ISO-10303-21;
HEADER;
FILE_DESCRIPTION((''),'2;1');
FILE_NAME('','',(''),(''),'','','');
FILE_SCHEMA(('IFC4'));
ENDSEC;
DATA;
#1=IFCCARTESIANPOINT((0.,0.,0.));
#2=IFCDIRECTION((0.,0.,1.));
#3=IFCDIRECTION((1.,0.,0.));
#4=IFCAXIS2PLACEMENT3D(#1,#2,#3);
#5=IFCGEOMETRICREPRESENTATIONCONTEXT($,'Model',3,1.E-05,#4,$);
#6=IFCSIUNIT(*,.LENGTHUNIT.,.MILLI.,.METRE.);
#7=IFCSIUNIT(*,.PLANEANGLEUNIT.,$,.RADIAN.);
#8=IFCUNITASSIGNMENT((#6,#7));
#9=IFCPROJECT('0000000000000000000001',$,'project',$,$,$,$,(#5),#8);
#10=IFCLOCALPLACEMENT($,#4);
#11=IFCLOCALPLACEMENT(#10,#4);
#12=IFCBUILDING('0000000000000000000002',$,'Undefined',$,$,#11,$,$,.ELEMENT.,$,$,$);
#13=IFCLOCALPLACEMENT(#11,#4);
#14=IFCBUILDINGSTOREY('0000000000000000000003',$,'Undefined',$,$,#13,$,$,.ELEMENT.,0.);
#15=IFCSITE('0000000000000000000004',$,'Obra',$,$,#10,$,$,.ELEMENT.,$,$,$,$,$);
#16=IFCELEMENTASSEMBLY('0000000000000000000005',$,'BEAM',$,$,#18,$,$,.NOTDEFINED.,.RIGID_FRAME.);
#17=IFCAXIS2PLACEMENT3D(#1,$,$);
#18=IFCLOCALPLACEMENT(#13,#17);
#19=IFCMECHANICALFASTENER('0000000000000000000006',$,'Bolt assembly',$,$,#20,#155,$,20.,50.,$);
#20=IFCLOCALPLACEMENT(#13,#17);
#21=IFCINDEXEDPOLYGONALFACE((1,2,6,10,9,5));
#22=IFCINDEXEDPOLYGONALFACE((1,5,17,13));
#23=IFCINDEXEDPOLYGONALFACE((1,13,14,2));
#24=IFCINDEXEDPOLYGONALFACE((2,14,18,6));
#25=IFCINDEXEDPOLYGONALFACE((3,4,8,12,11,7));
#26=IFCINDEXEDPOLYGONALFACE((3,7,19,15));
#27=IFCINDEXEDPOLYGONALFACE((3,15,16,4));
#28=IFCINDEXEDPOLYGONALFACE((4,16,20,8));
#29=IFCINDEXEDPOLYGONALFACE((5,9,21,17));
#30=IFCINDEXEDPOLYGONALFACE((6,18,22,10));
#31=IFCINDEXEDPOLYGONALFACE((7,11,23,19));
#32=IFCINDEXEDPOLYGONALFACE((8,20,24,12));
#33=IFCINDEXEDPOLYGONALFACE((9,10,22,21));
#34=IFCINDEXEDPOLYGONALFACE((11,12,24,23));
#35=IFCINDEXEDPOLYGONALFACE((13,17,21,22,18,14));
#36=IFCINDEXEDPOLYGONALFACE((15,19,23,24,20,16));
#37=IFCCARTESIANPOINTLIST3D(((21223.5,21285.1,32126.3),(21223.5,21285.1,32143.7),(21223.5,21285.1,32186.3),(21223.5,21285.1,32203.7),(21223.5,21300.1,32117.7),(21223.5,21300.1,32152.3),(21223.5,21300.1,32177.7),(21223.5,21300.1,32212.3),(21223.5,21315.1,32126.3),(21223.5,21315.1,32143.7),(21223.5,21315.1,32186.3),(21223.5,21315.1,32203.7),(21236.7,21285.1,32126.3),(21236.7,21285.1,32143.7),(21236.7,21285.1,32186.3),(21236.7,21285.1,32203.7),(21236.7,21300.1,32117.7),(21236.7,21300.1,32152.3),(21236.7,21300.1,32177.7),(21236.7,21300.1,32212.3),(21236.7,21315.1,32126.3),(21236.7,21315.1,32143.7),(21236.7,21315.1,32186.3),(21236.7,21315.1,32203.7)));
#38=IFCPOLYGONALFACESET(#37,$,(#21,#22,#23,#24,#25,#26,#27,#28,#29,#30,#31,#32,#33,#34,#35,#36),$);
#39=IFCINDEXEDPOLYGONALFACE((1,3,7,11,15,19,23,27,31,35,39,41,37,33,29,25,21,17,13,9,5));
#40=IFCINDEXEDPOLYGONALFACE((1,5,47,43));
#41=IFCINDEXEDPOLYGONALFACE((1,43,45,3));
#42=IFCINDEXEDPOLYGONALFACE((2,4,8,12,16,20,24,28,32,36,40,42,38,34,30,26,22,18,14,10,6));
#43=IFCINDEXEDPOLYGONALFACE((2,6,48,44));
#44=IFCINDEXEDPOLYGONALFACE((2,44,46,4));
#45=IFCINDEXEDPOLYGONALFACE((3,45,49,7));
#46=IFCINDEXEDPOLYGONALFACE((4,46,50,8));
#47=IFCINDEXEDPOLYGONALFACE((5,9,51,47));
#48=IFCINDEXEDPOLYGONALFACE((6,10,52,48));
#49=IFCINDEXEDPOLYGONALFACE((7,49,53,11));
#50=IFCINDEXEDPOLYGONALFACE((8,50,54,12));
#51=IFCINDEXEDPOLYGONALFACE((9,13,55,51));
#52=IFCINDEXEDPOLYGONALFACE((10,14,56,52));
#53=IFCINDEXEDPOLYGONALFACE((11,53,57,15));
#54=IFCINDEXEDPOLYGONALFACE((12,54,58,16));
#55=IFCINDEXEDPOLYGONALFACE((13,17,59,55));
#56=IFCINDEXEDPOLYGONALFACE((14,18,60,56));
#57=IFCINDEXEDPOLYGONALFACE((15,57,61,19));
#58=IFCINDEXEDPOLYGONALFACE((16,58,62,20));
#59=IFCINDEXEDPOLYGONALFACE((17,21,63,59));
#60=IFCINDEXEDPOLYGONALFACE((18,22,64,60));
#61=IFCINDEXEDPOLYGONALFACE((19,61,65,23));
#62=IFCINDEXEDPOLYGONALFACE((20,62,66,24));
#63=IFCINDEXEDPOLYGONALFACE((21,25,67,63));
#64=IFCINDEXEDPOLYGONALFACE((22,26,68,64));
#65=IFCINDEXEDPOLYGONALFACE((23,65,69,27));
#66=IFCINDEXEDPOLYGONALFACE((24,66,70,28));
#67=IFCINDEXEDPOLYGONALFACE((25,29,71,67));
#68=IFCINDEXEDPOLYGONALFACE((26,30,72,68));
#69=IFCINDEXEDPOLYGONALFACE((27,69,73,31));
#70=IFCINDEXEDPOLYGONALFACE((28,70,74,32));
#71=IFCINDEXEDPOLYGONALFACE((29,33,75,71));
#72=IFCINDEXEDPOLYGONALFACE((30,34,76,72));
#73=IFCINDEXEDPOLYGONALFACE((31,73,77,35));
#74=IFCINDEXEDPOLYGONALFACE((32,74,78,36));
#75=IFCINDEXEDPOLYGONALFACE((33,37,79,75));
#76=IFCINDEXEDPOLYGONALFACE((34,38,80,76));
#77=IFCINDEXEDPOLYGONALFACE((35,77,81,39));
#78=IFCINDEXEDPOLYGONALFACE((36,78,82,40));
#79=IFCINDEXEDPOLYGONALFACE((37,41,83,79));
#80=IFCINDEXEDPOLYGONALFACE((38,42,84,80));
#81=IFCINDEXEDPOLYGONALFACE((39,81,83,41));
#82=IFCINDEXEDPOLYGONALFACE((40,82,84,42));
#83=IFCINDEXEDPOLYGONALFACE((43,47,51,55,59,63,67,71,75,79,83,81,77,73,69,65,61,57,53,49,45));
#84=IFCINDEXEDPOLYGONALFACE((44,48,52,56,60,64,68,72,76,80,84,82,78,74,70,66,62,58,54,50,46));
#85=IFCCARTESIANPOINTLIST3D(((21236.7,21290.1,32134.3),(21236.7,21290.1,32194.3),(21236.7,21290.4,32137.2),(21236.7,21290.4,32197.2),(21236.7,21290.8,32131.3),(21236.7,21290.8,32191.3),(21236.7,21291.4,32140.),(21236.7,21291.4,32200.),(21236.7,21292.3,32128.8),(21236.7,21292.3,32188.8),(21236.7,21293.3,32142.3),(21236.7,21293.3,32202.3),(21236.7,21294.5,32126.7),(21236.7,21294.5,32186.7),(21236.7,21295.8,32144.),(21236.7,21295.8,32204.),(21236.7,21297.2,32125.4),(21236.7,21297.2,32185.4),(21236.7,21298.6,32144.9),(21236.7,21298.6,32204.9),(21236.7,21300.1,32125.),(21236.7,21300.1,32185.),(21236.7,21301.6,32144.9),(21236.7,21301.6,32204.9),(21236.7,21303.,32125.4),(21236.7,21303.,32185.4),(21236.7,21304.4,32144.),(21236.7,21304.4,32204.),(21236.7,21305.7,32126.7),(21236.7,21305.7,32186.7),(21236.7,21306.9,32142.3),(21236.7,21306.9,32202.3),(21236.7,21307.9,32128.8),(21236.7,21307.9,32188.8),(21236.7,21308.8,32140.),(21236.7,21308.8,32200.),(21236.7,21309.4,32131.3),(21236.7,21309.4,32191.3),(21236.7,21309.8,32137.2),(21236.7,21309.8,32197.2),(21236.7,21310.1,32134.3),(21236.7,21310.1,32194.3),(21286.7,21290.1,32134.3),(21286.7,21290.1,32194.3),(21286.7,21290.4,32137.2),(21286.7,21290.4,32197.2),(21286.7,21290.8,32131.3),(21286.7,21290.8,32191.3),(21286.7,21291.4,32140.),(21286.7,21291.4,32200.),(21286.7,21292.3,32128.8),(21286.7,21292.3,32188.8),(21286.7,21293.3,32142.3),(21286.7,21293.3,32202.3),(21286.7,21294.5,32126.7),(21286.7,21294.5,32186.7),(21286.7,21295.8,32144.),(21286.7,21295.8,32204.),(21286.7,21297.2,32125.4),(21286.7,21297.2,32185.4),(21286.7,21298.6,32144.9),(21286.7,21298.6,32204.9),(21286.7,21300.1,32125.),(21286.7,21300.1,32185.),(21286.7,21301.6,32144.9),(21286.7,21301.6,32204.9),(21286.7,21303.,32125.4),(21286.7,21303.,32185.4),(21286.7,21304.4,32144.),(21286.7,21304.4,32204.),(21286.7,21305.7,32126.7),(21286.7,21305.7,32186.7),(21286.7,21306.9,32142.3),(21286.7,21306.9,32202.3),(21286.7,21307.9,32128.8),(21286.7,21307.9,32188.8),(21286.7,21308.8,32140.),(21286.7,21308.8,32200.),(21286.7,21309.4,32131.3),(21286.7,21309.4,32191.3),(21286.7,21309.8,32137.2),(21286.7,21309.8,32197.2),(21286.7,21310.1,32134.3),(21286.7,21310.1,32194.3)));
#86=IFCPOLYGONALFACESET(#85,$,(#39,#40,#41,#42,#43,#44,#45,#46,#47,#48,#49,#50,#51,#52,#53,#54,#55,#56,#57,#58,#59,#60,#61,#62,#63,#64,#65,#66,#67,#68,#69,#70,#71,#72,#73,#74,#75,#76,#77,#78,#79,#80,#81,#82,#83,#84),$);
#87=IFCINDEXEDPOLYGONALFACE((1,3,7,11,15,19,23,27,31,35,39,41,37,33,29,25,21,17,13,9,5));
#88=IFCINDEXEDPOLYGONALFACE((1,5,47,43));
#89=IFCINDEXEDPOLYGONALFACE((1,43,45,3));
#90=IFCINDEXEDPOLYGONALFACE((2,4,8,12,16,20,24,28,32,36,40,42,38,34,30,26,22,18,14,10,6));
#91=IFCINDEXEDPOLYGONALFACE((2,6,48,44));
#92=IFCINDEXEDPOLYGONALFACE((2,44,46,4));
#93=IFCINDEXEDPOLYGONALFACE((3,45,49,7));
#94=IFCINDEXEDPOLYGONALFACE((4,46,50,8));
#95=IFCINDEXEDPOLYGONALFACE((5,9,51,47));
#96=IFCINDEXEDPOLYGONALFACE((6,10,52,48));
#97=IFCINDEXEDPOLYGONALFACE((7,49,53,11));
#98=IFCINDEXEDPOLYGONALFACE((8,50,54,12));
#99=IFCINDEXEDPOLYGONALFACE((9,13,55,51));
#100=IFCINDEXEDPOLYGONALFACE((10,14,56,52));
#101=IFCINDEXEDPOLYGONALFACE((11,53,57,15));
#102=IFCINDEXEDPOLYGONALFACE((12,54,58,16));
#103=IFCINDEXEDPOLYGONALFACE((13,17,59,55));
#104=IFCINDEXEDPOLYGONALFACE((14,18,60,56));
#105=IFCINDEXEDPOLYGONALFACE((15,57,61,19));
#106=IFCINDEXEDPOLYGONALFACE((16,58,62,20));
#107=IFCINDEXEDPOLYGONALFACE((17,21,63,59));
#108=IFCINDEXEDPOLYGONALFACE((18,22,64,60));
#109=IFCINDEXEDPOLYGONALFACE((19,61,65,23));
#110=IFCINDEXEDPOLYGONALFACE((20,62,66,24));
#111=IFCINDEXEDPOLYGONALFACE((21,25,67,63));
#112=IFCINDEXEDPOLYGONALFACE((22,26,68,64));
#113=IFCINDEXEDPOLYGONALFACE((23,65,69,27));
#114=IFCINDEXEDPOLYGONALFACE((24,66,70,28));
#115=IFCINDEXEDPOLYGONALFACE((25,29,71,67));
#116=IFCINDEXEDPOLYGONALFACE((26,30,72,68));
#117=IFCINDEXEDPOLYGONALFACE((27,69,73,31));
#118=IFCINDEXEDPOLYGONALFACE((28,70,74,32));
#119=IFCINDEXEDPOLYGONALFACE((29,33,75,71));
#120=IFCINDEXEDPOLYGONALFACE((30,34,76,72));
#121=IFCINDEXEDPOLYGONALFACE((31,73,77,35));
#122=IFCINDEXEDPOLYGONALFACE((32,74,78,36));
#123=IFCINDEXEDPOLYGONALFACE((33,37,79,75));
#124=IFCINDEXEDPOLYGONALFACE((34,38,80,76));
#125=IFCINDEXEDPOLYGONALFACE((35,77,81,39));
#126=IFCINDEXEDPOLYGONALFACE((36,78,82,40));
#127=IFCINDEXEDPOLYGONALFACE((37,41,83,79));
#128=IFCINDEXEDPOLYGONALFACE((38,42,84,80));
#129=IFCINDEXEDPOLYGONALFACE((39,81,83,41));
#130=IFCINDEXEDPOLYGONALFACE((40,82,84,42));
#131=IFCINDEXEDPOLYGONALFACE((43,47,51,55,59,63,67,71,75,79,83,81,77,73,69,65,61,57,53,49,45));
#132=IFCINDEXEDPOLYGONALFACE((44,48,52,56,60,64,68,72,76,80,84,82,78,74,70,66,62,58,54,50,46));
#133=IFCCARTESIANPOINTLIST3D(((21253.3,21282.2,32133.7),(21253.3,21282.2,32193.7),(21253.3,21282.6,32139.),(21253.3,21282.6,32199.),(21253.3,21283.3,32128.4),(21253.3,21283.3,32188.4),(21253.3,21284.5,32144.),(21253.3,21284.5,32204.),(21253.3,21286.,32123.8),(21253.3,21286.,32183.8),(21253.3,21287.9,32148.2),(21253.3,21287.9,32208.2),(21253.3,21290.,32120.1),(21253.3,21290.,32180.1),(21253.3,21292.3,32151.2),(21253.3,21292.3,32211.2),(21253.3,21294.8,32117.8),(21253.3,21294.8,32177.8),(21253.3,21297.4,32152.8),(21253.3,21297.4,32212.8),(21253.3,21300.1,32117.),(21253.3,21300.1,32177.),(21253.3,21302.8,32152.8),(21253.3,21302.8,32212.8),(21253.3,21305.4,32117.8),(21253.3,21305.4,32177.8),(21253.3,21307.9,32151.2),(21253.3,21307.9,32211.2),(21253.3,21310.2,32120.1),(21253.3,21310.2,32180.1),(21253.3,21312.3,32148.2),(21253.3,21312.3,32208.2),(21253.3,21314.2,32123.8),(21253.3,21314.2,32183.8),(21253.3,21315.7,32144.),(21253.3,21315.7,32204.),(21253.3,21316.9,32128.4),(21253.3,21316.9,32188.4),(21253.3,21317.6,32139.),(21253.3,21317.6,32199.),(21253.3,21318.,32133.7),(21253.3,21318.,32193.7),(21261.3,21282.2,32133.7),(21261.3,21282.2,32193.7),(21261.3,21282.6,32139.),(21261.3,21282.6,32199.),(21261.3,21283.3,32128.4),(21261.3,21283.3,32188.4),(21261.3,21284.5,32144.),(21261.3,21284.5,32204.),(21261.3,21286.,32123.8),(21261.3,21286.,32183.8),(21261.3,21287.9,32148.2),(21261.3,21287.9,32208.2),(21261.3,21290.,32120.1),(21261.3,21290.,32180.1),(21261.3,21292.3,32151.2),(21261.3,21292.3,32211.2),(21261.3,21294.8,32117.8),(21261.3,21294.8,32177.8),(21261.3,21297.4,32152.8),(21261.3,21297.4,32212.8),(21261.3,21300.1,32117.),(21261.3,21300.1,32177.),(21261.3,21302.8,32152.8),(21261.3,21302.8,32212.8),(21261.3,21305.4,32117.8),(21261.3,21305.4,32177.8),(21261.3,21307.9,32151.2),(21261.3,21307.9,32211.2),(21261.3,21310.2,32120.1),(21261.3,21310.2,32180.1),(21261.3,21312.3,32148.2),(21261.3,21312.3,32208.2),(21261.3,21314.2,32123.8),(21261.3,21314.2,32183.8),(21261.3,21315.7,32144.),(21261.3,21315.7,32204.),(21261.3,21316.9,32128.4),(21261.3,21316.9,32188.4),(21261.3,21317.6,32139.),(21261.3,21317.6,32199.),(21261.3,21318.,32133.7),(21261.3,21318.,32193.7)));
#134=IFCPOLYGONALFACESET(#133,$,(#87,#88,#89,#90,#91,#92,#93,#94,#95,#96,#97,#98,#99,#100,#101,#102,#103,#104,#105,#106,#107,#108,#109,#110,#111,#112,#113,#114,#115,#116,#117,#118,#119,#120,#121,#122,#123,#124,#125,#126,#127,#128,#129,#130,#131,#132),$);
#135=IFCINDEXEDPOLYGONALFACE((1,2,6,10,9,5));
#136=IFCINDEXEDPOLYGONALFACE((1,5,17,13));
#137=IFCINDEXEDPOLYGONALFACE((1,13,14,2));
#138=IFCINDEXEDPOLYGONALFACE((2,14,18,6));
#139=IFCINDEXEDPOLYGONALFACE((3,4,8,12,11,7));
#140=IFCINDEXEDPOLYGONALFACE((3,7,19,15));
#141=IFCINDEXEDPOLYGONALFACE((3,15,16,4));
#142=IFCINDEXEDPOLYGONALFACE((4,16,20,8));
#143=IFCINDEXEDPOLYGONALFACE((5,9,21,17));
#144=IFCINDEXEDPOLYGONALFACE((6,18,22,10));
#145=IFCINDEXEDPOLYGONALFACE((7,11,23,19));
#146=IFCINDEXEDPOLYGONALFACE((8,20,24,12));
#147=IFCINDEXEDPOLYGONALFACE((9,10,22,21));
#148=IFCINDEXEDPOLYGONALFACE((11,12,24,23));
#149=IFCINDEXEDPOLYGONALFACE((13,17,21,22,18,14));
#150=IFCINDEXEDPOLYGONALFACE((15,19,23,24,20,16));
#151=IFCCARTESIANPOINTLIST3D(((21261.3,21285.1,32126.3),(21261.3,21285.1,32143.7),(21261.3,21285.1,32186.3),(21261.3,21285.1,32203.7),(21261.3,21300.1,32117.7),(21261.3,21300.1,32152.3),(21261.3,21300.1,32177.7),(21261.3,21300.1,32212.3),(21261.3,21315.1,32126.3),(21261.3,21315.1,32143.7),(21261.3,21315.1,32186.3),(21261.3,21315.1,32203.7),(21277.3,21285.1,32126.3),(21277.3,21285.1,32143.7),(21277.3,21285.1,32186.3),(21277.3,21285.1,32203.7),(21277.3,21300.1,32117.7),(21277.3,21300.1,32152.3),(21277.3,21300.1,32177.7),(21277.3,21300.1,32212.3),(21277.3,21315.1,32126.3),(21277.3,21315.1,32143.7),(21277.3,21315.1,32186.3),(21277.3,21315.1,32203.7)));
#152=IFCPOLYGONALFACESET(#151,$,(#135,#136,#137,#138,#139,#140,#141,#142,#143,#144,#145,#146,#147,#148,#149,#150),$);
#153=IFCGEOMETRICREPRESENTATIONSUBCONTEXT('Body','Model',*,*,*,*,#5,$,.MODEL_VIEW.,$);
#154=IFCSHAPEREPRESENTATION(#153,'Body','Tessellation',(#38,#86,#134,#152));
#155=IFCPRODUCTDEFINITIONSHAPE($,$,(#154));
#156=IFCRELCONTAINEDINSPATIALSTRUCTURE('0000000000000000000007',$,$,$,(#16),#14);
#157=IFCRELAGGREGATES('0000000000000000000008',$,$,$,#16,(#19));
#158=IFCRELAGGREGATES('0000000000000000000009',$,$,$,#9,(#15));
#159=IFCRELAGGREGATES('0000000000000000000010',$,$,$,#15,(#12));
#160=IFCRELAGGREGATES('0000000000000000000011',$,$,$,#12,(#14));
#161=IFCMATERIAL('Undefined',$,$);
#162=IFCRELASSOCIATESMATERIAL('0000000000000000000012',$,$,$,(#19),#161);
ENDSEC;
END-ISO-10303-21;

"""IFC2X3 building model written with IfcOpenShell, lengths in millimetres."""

from ifc_helpers import new_model, si_unit, frame, origin_with_axes, origin_2d_with_axis, place, context, subcontext, project, spatial, polyline, circle, outline, extrude, source, transform, mapped, material, element, aggregate, save


model = new_model("IFC2X3")

# Units and contexts
model_context = context("Model", 3, precision=1e-05, world=origin_with_axes())
body_context = subcontext(model_context, "Body", "Model", "MODEL_VIEW")
ifc_project = project(units=[si_unit("LENGTHUNIT", "METRE", prefix="MILLI"), si_unit("PLANEANGLEUNIT", "RADIAN")], contexts=[model_context])

# Site, building, storey
site_placement = place(None, origin_with_axes())
site = spatial("IfcSite", under=ifc_project, at=site_placement, Name="Obra", CompositionType="ELEMENT")
building_placement = place(site_placement, origin_with_axes())
building = spatial("IfcBuilding", under=site, at=building_placement, Name="Undefined", CompositionType="ELEMENT")
storey_placement = place(building_placement, origin_with_axes())
storey = spatial("IfcBuildingStorey", under=building, at=storey_placement, Name="Undefined", CompositionType="ELEMENT", Elevation=0.0)

# Shared definitions
ifc_material_1 = material(Name="Undefined")

# Element assembly, mechanical fastener
assembly_1_placement = place(storey_placement, origin_with_axes())
assembly_1 = element("IfcElementAssembly", 1, at=assembly_1_placement, inside=storey, Name="BEAM", AssemblyPlace="NOTDEFINED", PredefinedType="RIGID_FRAME")
shared_shape_1 = source(origin_with_axes(), body_context, "Body", "SweptSolid", [
    extrude(outline(polyline([(17.3, 0.0), (8.7, 15.0), (-8.7, 15.0), (-17.3, 0.0), (-8.7, -15.0), (8.7, -15.0), (17.3, 0.0)])), frame((0.0, -26.5, 0.0), z_axis=(0.0, 1.0, 0.0), x_axis=(1.0, 0.0, 0.0)), (0.0, 0.0, 1.0), 13.2),
    extrude(circle(Radius=10.0, at=origin_2d_with_axis()), frame((0.0, -13.3, 0.0), z_axis=(0.0, 1.0, 0.0), x_axis=(1.0, 0.0, 0.0)), (0.0, 0.0, 1.0), 50.0),
    extrude(circle(Radius=18.0, at=origin_2d_with_axis()), frame((0.0, 3.3, 0.0), z_axis=(0.0, 1.0, 0.0), x_axis=(1.0, 0.0, 0.0)), (0.0, 0.0, 1.0), 8.0),
    extrude(outline(polyline([(17.3, 0.0), (8.7, 15.0), (-8.7, 15.0), (-17.3, 0.0), (-8.7, -15.0), (8.7, -15.0), (17.3, 0.0)])), frame((0.0, 11.3, 0.0), z_axis=(0.0, 1.0, 0.0), x_axis=(1.0, 0.0, 0.0)), (0.0, 0.0, 1.0), 16.0),
])
mechanical_fastener_1_placement = place(assembly_1_placement, frame((21250.0, 21340.1, 32235.0), z_axis=(0.0, -1.0, 0.0), x_axis=(0.0, 0.0, -1.0)))
mechanical_fastener_1 = element("IfcMechanicalFastener", 2, at=mechanical_fastener_1_placement, material=ifc_material_1, Name="Bolt assembly", NominalDiameter=20.0, NominalLength=50.0, context=body_context, shape_type="MappedRepresentation", body=[
    mapped(shared_shape_1, transform((40.0, 0.0, 40.0))),
    mapped(shared_shape_1, transform((100.0, 0.0, 40.0))),
])
aggregate(assembly_1, [mechanical_fastener_1])

save(model, "model.ifc")
